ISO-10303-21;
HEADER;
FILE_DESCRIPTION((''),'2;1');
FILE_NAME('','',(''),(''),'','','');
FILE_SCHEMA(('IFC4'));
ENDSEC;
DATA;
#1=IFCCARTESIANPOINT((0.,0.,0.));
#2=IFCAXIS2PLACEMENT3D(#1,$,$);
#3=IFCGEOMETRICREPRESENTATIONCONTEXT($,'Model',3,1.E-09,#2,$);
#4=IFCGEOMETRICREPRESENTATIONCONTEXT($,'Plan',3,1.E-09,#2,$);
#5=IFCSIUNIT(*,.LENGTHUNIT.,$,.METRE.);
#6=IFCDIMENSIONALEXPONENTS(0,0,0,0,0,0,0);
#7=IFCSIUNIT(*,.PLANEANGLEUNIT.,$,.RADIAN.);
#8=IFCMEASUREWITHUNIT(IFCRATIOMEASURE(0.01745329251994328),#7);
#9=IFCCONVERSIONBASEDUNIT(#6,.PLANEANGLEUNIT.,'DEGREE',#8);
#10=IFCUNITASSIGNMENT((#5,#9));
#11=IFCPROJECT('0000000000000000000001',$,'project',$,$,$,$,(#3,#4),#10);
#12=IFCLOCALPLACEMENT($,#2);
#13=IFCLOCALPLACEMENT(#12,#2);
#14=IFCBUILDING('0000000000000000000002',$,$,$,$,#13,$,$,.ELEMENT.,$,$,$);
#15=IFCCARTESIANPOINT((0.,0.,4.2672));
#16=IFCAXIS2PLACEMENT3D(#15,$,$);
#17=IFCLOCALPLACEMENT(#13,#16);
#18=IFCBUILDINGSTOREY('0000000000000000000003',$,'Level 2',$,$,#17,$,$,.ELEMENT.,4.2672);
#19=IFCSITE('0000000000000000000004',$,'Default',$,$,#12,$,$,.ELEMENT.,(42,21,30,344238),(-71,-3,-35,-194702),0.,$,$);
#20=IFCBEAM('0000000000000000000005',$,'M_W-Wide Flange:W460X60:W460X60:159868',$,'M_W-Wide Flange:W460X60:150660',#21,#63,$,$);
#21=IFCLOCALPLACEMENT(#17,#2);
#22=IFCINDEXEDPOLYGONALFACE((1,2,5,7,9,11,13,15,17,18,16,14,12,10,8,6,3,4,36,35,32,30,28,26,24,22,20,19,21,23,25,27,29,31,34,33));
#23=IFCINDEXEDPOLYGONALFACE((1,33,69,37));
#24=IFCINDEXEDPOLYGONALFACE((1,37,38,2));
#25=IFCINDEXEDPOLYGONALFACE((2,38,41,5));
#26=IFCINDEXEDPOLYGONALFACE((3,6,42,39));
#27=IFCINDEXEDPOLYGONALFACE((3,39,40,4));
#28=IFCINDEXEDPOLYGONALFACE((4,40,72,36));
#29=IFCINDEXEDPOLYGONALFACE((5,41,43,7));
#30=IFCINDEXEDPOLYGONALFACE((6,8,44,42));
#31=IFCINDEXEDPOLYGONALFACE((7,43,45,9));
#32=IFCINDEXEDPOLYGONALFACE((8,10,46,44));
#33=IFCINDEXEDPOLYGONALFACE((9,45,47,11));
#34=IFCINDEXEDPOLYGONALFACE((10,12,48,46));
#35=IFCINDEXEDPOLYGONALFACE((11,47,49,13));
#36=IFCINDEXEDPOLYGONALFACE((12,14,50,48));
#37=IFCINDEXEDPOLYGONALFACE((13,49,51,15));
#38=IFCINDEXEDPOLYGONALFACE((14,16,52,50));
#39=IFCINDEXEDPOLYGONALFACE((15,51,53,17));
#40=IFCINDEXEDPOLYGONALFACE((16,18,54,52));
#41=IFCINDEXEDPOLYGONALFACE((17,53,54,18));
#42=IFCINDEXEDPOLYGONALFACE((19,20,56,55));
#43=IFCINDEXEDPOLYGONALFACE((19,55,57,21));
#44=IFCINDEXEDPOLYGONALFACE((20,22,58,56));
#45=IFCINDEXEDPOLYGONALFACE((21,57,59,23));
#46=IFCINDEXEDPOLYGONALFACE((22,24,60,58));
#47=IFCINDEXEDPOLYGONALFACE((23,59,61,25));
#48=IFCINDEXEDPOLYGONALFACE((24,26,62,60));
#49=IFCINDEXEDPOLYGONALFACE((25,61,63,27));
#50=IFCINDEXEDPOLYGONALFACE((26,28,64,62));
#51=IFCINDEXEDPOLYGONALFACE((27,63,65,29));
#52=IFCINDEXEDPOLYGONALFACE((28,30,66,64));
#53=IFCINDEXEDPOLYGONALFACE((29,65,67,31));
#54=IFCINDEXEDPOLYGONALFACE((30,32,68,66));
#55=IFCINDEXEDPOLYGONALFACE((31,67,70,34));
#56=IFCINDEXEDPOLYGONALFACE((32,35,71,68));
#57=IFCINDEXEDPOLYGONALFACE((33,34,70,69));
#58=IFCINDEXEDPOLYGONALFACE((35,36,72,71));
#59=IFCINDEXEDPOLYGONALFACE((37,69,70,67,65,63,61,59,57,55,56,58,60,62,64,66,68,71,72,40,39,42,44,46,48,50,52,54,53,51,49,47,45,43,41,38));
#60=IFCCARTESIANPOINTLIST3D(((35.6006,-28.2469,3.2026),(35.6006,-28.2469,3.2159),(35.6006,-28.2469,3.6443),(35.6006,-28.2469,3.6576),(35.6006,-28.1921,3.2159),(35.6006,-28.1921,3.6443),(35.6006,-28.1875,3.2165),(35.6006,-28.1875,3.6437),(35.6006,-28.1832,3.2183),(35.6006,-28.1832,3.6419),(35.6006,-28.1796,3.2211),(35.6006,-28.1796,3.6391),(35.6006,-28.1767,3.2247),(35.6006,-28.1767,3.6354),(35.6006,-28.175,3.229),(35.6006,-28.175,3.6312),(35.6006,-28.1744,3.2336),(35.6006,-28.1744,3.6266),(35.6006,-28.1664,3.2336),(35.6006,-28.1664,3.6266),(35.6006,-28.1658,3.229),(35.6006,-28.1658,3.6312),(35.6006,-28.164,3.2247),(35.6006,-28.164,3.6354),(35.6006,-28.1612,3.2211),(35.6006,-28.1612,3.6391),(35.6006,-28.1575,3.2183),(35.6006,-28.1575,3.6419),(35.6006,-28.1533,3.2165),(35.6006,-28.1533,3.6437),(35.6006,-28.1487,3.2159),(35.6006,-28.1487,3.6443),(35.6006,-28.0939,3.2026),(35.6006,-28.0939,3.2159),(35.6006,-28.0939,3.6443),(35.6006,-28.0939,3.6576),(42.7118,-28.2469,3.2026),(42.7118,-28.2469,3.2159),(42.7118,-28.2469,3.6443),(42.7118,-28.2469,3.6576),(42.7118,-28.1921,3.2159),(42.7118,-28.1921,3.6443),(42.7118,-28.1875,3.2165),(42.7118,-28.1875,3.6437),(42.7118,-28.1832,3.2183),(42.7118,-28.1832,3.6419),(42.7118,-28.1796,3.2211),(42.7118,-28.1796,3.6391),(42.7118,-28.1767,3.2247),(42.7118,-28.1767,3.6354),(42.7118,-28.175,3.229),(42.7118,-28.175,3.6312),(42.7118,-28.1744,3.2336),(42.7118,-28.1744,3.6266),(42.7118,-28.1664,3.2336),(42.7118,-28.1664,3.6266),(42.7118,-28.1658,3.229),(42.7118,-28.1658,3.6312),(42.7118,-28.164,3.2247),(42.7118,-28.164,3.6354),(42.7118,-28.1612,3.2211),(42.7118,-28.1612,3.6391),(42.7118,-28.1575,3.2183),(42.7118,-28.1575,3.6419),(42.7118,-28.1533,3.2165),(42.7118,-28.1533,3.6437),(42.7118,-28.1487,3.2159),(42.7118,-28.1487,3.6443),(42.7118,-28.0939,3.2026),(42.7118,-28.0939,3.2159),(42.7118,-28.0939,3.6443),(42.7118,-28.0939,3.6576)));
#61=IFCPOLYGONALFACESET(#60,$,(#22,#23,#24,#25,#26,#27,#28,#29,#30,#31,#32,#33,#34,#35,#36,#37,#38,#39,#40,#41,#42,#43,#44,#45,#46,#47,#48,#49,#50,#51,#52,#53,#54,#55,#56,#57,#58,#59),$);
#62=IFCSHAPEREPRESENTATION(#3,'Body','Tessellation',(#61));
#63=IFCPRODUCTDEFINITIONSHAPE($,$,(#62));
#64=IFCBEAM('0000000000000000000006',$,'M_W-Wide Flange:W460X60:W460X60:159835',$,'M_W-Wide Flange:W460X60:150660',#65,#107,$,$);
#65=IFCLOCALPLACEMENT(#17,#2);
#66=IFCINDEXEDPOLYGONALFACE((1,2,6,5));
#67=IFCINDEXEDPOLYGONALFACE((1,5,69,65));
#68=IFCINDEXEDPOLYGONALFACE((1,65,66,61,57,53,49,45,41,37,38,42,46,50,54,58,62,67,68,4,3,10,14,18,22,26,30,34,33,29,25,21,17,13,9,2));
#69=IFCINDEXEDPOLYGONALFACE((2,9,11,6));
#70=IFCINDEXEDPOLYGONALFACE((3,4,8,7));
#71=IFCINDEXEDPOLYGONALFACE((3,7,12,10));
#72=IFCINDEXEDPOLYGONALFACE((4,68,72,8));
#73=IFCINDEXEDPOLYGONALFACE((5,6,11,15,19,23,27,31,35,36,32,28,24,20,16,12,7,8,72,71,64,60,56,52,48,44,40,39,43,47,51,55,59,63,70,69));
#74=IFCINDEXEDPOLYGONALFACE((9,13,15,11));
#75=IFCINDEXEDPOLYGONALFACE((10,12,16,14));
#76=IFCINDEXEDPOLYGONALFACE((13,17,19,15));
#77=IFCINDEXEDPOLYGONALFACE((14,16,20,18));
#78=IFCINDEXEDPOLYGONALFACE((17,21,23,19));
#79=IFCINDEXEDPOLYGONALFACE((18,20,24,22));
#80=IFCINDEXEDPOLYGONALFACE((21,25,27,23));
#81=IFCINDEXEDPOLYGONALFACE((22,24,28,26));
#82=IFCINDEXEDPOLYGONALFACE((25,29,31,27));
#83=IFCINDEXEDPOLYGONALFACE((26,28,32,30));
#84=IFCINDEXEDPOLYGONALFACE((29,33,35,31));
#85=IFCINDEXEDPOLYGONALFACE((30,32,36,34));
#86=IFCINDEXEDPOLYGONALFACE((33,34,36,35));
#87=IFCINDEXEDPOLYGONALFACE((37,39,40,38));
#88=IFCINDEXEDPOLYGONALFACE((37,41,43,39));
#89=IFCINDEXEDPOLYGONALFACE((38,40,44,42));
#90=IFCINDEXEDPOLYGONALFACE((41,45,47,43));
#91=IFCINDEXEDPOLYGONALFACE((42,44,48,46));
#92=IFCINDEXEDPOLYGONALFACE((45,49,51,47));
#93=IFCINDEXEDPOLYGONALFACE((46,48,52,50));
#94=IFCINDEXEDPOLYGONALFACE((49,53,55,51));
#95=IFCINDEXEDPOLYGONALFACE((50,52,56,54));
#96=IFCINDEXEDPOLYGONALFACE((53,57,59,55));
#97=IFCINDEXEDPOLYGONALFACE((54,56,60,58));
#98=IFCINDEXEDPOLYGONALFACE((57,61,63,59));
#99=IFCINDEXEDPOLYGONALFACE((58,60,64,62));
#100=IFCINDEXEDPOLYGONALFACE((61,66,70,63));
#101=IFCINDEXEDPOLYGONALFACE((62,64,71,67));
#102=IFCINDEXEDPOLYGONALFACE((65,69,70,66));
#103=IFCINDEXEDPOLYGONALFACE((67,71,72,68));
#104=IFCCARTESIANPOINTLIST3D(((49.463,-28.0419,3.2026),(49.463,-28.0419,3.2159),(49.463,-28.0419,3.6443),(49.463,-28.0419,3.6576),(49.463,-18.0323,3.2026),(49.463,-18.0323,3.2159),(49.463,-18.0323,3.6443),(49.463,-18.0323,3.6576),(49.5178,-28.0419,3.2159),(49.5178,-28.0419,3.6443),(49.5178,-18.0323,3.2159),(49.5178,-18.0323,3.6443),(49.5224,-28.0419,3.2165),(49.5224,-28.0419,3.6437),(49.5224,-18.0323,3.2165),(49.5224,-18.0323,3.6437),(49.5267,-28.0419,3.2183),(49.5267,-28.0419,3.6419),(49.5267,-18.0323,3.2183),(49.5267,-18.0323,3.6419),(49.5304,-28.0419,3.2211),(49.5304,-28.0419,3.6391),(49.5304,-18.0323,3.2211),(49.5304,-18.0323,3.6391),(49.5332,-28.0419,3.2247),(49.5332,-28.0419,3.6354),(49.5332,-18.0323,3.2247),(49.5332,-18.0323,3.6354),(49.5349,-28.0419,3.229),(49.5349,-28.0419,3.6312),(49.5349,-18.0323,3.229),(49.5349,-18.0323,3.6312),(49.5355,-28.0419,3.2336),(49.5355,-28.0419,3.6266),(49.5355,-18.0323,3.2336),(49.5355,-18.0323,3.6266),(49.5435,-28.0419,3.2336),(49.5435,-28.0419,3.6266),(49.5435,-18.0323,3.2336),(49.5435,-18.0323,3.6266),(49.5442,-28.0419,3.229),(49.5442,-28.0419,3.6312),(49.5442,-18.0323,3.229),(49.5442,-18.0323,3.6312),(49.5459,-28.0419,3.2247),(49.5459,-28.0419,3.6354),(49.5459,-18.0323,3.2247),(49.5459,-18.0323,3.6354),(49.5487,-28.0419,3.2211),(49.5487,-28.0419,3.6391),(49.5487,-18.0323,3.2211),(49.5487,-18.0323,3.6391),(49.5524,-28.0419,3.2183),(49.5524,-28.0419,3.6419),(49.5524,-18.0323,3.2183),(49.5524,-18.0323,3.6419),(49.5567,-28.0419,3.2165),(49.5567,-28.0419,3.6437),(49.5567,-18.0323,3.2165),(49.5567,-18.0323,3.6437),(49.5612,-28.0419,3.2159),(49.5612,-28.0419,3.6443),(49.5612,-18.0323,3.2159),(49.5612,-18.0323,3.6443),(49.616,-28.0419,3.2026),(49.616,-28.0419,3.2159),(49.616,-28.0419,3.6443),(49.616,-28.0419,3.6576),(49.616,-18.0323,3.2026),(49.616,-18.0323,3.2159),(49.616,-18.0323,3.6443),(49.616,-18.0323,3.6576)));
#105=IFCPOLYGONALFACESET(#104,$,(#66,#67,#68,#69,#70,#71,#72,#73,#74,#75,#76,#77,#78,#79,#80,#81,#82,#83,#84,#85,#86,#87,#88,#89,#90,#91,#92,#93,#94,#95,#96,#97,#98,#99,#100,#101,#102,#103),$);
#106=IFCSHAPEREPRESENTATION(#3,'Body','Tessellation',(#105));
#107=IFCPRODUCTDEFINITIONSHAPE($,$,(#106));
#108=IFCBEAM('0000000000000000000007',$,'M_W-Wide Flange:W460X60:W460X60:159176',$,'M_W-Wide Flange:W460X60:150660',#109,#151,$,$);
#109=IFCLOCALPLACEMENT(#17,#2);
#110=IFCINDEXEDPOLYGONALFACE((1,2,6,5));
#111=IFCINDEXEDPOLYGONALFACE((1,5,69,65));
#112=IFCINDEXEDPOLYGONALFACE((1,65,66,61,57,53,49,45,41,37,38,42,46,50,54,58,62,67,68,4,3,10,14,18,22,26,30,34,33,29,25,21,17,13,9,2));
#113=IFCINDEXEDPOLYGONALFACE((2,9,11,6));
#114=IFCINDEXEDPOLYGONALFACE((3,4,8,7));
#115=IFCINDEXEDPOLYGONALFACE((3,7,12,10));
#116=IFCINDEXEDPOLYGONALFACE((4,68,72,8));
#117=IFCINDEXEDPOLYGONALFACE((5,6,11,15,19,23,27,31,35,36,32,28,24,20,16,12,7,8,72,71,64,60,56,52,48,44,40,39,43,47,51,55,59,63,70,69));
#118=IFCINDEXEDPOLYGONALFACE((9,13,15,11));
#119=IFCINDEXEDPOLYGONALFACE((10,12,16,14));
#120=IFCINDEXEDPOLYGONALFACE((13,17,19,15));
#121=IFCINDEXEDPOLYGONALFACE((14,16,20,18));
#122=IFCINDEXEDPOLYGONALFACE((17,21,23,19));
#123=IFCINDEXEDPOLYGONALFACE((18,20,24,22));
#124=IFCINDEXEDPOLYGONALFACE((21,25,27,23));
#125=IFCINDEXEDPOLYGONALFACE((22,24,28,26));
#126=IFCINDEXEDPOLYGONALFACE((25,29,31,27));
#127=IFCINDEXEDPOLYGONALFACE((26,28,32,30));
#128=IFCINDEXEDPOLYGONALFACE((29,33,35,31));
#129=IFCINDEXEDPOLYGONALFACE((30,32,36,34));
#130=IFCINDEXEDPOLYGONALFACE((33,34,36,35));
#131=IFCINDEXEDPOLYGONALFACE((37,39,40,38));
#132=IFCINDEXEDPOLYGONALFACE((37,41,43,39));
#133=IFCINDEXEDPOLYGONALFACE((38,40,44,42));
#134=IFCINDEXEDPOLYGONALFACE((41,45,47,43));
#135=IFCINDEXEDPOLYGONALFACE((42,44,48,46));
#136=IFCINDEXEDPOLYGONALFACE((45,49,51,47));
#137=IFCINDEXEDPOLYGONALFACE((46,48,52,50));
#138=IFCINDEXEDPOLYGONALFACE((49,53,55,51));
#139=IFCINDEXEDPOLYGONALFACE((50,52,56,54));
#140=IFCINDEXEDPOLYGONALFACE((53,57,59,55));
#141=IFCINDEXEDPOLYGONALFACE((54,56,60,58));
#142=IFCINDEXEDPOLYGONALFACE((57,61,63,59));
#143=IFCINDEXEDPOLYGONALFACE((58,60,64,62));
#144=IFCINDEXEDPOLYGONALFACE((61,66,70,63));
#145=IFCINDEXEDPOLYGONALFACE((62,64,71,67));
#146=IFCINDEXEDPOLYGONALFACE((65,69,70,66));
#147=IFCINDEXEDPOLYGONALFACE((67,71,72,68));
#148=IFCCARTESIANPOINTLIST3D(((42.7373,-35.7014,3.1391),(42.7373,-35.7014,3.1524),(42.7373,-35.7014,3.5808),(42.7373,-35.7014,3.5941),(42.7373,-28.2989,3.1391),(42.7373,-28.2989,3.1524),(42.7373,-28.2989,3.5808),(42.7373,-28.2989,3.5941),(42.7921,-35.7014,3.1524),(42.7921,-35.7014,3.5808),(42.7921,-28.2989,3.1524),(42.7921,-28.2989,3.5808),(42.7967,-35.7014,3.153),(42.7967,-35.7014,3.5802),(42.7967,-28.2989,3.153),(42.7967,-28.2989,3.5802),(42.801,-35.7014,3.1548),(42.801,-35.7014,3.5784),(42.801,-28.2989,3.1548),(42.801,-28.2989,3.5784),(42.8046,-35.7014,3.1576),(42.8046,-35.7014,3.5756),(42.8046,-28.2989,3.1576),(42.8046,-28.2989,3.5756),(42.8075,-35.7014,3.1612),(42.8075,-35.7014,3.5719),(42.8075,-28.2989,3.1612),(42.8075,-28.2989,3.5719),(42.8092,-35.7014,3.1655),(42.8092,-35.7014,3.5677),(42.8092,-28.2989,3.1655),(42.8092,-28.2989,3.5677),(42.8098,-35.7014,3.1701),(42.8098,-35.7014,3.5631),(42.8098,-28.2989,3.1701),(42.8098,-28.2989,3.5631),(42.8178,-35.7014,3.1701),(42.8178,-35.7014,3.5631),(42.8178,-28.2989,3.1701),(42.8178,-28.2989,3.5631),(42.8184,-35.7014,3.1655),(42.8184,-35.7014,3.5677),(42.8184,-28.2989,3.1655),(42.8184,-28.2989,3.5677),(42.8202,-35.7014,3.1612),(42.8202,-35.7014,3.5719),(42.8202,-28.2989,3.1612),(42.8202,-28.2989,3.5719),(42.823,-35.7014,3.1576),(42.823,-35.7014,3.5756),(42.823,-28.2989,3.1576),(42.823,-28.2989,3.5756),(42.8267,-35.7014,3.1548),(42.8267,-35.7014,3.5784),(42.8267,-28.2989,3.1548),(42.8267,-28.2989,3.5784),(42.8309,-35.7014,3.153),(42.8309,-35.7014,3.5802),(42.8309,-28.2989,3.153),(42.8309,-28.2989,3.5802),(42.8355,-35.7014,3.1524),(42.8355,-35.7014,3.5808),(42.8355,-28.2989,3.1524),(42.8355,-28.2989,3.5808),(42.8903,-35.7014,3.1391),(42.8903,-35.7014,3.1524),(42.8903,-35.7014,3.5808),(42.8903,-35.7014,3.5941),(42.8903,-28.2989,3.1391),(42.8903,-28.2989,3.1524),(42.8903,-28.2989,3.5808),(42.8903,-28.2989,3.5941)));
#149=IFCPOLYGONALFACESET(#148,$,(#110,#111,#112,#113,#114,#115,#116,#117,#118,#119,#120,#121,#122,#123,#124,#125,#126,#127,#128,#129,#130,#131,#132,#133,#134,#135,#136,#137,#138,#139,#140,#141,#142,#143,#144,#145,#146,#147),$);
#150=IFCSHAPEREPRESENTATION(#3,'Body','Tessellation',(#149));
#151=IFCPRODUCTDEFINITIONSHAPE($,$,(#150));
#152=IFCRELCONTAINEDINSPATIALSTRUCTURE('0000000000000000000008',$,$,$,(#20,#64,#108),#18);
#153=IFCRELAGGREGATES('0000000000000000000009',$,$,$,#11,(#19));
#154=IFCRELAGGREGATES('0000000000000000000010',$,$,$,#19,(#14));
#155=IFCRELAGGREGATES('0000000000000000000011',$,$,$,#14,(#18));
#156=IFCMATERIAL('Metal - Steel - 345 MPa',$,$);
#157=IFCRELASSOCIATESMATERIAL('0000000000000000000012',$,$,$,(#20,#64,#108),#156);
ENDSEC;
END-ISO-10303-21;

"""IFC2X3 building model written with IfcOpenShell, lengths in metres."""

from ifc_helpers import new_model, entity, si_unit, converted_unit, frame, frame_2d, origin, place, context, project, spatial, polyline, circle_curve, parameter, trimmed, segment, composite_curve, outline, extrude, material, element, save


model = new_model("IFC2X3")

# Units and contexts
model_context = context("Model", 3, precision=1e-09, world=origin())
plan_context = context("Plan", 3, precision=1e-09, world=origin())
ifc_project = project(units=[si_unit("LENGTHUNIT", "METRE"), converted_unit("PLANEANGLEUNIT", "DEGREE", entity("IfcRatioMeasure", 0.01745329251994328), si_unit("PLANEANGLEUNIT", "RADIAN"), dimensions=[0, 0, 0, 0, 0, 0, 0])], contexts=[model_context, plan_context])

# Site, building, storey
site_placement = place(None, origin())
site = spatial("IfcSite", under=ifc_project, at=site_placement, Name="Default", CompositionType="ELEMENT", RefLatitude=(42, 21, 30, 344238), RefLongitude=(-71, -3, -35, -194702), RefElevation=0.0)
building_placement = place(site_placement, origin())
building = spatial("IfcBuilding", under=site, at=building_placement, CompositionType="ELEMENT")
storey_placement = place(building_placement, frame((0.0, 0.0, 4.2672)))
storey = spatial("IfcBuildingStorey", under=building, at=storey_placement, Name="Level 2", CompositionType="ELEMENT", Elevation=4.2672)

# Shared definitions
ifc_material = material(Name="Metal - Steel - 345 MPa")

# Beams
beam_1_placement = place(storey_placement, frame((42.8138, -28.1704, 3.6576), z_axis=(0.0, 0.0, 1.0), x_axis=(0.0, 1.0, 0.0)))
element("IfcBeam", 1, at=beam_1_placement, inside=storey, material=ifc_material, Name="M_W-Wide Flange:W460X60:W460X60:159868", ObjectType="M_W-Wide Flange:W460X60:150660", context=model_context, shape_type="SweptSolid", body=[
    extrude(outline(composite_curve([segment(polyline([(0.2142, -0.0765), (0.2275, -0.0765)]), True, "CONTINUOUS"), segment(polyline([(0.2275, -0.0765), (0.2275, 0.0765)]), True, "CONTINUOUS"), segment(polyline([(0.2275, 0.0765), (0.2142, 0.0765)]), True, "CONTINUOUS"), segment(polyline([(0.2142, 0.0765), (0.2142, 0.0217)]), True, "CONTINUOUS"), segment(trimmed(circle_curve(frame_2d((0.1965, 0.0217), x_axis=(1.0, 0.0)), 0.0177), [parameter(270.0)], [parameter(360.0)], True, "PARAMETER"), False, "CONTINUOUS"), segment(polyline([(0.1965, 0.004), (-0.1965, 0.004)]), True, "CONTINUOUS"), segment(trimmed(circle_curve(frame_2d((-0.1965, 0.0217), x_axis=(0.0, -1.0)), 0.0177), [parameter(270.0)], [parameter(360.0)], True, "PARAMETER"), False, "CONTINUOUS"), segment(polyline([(-0.2142, 0.0217), (-0.2142, 0.0765)]), True, "CONTINUOUS"), segment(polyline([(-0.2142, 0.0765), (-0.2275, 0.0765)]), True, "CONTINUOUS"), segment(polyline([(-0.2275, 0.0765), (-0.2275, -0.0765)]), True, "CONTINUOUS"), segment(polyline([(-0.2275, -0.0765), (-0.2142, -0.0765)]), True, "CONTINUOUS"), segment(polyline([(-0.2142, -0.0765), (-0.2142, -0.0217)]), True, "CONTINUOUS"), segment(trimmed(circle_curve(frame_2d((-0.1965, -0.0217), x_axis=(-1.0, 0.0)), 0.0177), [parameter(270.0)], [parameter(360.0)], True, "PARAMETER"), False, "CONTINUOUS"), segment(polyline([(-0.1965, -0.004), (0.1965, -0.004)]), True, "CONTINUOUS"), segment(trimmed(circle_curve(frame_2d((0.1965, -0.0217), x_axis=(0.0, 1.0)), 0.0177), [parameter(270.0)], [parameter(0.0)], True, "PARAMETER"), False, "CONTINUOUS"), segment(polyline([(0.2142, -0.0217), (0.2142, -0.0765)]), True, "CONTINUOUS")], self_intersect=False)), frame((0.0, 7.2132, -0.2275), z_axis=(0.0, -1.0, 0.0), x_axis=(0.0, 0.0, -1.0)), (0.0, 0.0, 1.0), 7.1112),
])
beam_2_placement = place(storey_placement, frame((49.5395, -17.9038, 3.6576), z_axis=(0.0, 0.0, 1.0), x_axis=(-1.0, 0.0, 0.0)))
element("IfcBeam", 2, at=beam_2_placement, inside=storey, material=ifc_material, Name="M_W-Wide Flange:W460X60:W460X60:159835", ObjectType="M_W-Wide Flange:W460X60:150660", context=model_context, shape_type="SweptSolid", body=[
    extrude(outline(composite_curve([segment(polyline([(0.2142, -0.0765), (0.2275, -0.0765)]), True, "CONTINUOUS"), segment(polyline([(0.2275, -0.0765), (0.2275, 0.0765)]), True, "CONTINUOUS"), segment(polyline([(0.2275, 0.0765), (0.2142, 0.0765)]), True, "CONTINUOUS"), segment(polyline([(0.2142, 0.0765), (0.2142, 0.0217)]), True, "CONTINUOUS"), segment(trimmed(circle_curve(frame_2d((0.1965, 0.0217), x_axis=(1.0, 0.0)), 0.0177), [parameter(270.0)], [parameter(360.0)], True, "PARAMETER"), False, "CONTINUOUS"), segment(polyline([(0.1965, 0.004), (-0.1965, 0.004)]), True, "CONTINUOUS"), segment(trimmed(circle_curve(frame_2d((-0.1965, 0.0217), x_axis=(0.0, -1.0)), 0.0177), [parameter(270.0)], [parameter(360.0)], True, "PARAMETER"), False, "CONTINUOUS"), segment(polyline([(-0.2142, 0.0217), (-0.2142, 0.0765)]), True, "CONTINUOUS"), segment(polyline([(-0.2142, 0.0765), (-0.2275, 0.0765)]), True, "CONTINUOUS"), segment(polyline([(-0.2275, 0.0765), (-0.2275, -0.0765)]), True, "CONTINUOUS"), segment(polyline([(-0.2275, -0.0765), (-0.2142, -0.0765)]), True, "CONTINUOUS"), segment(polyline([(-0.2142, -0.0765), (-0.2142, -0.0217)]), True, "CONTINUOUS"), segment(trimmed(circle_curve(frame_2d((-0.1965, -0.0217), x_axis=(-1.0, 0.0)), 0.0177), [parameter(270.0)], [parameter(360.0)], True, "PARAMETER"), False, "CONTINUOUS"), segment(polyline([(-0.1965, -0.004), (0.1965, -0.004)]), True, "CONTINUOUS"), segment(trimmed(circle_curve(frame_2d((0.1965, -0.0217), x_axis=(0.0, 1.0)), 0.0177), [parameter(270.0)], [parameter(0.0)], True, "PARAMETER"), False, "CONTINUOUS"), segment(polyline([(0.2142, -0.0217), (0.2142, -0.0765)]), True, "CONTINUOUS")], self_intersect=False)), frame((0.0, 10.138, -0.2275), z_axis=(0.0, -1.0, 0.0), x_axis=(0.0, 0.0, -1.0)), (0.0, 0.0, 1.0), 10.0095),
])
beam_3_placement = place(storey_placement, frame((42.8138, -35.8299, 3.6576)))
element("IfcBeam", 3, at=beam_3_placement, inside=storey, material=ifc_material, Name="M_W-Wide Flange:W460X60:W460X60:159176", ObjectType="M_W-Wide Flange:W460X60:150660", context=model_context, shape_type="SweptSolid", body=[
    extrude(outline(composite_curve([segment(polyline([(-0.0765, -0.2142), (-0.0765, -0.2275)]), True, "CONTINUOUS"), segment(polyline([(-0.0765, -0.2275), (0.0765, -0.2275)]), True, "CONTINUOUS"), segment(polyline([(0.0765, -0.2275), (0.0765, -0.2142)]), True, "CONTINUOUS"), segment(polyline([(0.0765, -0.2142), (0.0217, -0.2142)]), True, "CONTINUOUS"), segment(trimmed(circle_curve(frame_2d((0.0217, -0.1965), x_axis=(0.0, -1.0)), 0.0177), [parameter(270.0)], [parameter(360.0)], True, "PARAMETER"), False, "CONTINUOUS"), segment(polyline([(0.004, -0.1965), (0.004, 0.1965)]), True, "CONTINUOUS"), segment(trimmed(circle_curve(frame_2d((0.0217, 0.1965), x_axis=(-1.0, 0.0)), 0.0177), [parameter(270.0)], [parameter(360.0)], True, "PARAMETER"), False, "CONTINUOUS"), segment(polyline([(0.0217, 0.2142), (0.0765, 0.2142)]), True, "CONTINUOUS"), segment(polyline([(0.0765, 0.2142), (0.0765, 0.2275)]), True, "CONTINUOUS"), segment(polyline([(0.0765, 0.2275), (-0.0765, 0.2275)]), True, "CONTINUOUS"), segment(polyline([(-0.0765, 0.2275), (-0.0765, 0.2142)]), True, "CONTINUOUS"), segment(polyline([(-0.0765, 0.2142), (-0.0217, 0.2142)]), True, "CONTINUOUS"), segment(trimmed(circle_curve(frame_2d((-0.0217, 0.1965), x_axis=(0.0, 1.0)), 0.0177), [parameter(270.0)], [parameter(360.0)], True, "PARAMETER"), False, "CONTINUOUS"), segment(polyline([(-0.004, 0.1965), (-0.004, -0.1965)]), True, "CONTINUOUS"), segment(trimmed(circle_curve(frame_2d((-0.0217, -0.1965), x_axis=(1.0, 0.0)), 0.0177), [parameter(270.0)], [parameter(0.0)], True, "PARAMETER"), False, "CONTINUOUS"), segment(polyline([(-0.0217, -0.2142), (-0.0765, -0.2142)]), True, "CONTINUOUS")], self_intersect=False)), frame((0.0, 0.1285, -0.291), z_axis=(0.0, -1.0, 0.0), x_axis=(1.0, 0.0, 0.0)), (0.0, 0.0, -1.0), 7.4025),
])

save(model, "model.ifc")
